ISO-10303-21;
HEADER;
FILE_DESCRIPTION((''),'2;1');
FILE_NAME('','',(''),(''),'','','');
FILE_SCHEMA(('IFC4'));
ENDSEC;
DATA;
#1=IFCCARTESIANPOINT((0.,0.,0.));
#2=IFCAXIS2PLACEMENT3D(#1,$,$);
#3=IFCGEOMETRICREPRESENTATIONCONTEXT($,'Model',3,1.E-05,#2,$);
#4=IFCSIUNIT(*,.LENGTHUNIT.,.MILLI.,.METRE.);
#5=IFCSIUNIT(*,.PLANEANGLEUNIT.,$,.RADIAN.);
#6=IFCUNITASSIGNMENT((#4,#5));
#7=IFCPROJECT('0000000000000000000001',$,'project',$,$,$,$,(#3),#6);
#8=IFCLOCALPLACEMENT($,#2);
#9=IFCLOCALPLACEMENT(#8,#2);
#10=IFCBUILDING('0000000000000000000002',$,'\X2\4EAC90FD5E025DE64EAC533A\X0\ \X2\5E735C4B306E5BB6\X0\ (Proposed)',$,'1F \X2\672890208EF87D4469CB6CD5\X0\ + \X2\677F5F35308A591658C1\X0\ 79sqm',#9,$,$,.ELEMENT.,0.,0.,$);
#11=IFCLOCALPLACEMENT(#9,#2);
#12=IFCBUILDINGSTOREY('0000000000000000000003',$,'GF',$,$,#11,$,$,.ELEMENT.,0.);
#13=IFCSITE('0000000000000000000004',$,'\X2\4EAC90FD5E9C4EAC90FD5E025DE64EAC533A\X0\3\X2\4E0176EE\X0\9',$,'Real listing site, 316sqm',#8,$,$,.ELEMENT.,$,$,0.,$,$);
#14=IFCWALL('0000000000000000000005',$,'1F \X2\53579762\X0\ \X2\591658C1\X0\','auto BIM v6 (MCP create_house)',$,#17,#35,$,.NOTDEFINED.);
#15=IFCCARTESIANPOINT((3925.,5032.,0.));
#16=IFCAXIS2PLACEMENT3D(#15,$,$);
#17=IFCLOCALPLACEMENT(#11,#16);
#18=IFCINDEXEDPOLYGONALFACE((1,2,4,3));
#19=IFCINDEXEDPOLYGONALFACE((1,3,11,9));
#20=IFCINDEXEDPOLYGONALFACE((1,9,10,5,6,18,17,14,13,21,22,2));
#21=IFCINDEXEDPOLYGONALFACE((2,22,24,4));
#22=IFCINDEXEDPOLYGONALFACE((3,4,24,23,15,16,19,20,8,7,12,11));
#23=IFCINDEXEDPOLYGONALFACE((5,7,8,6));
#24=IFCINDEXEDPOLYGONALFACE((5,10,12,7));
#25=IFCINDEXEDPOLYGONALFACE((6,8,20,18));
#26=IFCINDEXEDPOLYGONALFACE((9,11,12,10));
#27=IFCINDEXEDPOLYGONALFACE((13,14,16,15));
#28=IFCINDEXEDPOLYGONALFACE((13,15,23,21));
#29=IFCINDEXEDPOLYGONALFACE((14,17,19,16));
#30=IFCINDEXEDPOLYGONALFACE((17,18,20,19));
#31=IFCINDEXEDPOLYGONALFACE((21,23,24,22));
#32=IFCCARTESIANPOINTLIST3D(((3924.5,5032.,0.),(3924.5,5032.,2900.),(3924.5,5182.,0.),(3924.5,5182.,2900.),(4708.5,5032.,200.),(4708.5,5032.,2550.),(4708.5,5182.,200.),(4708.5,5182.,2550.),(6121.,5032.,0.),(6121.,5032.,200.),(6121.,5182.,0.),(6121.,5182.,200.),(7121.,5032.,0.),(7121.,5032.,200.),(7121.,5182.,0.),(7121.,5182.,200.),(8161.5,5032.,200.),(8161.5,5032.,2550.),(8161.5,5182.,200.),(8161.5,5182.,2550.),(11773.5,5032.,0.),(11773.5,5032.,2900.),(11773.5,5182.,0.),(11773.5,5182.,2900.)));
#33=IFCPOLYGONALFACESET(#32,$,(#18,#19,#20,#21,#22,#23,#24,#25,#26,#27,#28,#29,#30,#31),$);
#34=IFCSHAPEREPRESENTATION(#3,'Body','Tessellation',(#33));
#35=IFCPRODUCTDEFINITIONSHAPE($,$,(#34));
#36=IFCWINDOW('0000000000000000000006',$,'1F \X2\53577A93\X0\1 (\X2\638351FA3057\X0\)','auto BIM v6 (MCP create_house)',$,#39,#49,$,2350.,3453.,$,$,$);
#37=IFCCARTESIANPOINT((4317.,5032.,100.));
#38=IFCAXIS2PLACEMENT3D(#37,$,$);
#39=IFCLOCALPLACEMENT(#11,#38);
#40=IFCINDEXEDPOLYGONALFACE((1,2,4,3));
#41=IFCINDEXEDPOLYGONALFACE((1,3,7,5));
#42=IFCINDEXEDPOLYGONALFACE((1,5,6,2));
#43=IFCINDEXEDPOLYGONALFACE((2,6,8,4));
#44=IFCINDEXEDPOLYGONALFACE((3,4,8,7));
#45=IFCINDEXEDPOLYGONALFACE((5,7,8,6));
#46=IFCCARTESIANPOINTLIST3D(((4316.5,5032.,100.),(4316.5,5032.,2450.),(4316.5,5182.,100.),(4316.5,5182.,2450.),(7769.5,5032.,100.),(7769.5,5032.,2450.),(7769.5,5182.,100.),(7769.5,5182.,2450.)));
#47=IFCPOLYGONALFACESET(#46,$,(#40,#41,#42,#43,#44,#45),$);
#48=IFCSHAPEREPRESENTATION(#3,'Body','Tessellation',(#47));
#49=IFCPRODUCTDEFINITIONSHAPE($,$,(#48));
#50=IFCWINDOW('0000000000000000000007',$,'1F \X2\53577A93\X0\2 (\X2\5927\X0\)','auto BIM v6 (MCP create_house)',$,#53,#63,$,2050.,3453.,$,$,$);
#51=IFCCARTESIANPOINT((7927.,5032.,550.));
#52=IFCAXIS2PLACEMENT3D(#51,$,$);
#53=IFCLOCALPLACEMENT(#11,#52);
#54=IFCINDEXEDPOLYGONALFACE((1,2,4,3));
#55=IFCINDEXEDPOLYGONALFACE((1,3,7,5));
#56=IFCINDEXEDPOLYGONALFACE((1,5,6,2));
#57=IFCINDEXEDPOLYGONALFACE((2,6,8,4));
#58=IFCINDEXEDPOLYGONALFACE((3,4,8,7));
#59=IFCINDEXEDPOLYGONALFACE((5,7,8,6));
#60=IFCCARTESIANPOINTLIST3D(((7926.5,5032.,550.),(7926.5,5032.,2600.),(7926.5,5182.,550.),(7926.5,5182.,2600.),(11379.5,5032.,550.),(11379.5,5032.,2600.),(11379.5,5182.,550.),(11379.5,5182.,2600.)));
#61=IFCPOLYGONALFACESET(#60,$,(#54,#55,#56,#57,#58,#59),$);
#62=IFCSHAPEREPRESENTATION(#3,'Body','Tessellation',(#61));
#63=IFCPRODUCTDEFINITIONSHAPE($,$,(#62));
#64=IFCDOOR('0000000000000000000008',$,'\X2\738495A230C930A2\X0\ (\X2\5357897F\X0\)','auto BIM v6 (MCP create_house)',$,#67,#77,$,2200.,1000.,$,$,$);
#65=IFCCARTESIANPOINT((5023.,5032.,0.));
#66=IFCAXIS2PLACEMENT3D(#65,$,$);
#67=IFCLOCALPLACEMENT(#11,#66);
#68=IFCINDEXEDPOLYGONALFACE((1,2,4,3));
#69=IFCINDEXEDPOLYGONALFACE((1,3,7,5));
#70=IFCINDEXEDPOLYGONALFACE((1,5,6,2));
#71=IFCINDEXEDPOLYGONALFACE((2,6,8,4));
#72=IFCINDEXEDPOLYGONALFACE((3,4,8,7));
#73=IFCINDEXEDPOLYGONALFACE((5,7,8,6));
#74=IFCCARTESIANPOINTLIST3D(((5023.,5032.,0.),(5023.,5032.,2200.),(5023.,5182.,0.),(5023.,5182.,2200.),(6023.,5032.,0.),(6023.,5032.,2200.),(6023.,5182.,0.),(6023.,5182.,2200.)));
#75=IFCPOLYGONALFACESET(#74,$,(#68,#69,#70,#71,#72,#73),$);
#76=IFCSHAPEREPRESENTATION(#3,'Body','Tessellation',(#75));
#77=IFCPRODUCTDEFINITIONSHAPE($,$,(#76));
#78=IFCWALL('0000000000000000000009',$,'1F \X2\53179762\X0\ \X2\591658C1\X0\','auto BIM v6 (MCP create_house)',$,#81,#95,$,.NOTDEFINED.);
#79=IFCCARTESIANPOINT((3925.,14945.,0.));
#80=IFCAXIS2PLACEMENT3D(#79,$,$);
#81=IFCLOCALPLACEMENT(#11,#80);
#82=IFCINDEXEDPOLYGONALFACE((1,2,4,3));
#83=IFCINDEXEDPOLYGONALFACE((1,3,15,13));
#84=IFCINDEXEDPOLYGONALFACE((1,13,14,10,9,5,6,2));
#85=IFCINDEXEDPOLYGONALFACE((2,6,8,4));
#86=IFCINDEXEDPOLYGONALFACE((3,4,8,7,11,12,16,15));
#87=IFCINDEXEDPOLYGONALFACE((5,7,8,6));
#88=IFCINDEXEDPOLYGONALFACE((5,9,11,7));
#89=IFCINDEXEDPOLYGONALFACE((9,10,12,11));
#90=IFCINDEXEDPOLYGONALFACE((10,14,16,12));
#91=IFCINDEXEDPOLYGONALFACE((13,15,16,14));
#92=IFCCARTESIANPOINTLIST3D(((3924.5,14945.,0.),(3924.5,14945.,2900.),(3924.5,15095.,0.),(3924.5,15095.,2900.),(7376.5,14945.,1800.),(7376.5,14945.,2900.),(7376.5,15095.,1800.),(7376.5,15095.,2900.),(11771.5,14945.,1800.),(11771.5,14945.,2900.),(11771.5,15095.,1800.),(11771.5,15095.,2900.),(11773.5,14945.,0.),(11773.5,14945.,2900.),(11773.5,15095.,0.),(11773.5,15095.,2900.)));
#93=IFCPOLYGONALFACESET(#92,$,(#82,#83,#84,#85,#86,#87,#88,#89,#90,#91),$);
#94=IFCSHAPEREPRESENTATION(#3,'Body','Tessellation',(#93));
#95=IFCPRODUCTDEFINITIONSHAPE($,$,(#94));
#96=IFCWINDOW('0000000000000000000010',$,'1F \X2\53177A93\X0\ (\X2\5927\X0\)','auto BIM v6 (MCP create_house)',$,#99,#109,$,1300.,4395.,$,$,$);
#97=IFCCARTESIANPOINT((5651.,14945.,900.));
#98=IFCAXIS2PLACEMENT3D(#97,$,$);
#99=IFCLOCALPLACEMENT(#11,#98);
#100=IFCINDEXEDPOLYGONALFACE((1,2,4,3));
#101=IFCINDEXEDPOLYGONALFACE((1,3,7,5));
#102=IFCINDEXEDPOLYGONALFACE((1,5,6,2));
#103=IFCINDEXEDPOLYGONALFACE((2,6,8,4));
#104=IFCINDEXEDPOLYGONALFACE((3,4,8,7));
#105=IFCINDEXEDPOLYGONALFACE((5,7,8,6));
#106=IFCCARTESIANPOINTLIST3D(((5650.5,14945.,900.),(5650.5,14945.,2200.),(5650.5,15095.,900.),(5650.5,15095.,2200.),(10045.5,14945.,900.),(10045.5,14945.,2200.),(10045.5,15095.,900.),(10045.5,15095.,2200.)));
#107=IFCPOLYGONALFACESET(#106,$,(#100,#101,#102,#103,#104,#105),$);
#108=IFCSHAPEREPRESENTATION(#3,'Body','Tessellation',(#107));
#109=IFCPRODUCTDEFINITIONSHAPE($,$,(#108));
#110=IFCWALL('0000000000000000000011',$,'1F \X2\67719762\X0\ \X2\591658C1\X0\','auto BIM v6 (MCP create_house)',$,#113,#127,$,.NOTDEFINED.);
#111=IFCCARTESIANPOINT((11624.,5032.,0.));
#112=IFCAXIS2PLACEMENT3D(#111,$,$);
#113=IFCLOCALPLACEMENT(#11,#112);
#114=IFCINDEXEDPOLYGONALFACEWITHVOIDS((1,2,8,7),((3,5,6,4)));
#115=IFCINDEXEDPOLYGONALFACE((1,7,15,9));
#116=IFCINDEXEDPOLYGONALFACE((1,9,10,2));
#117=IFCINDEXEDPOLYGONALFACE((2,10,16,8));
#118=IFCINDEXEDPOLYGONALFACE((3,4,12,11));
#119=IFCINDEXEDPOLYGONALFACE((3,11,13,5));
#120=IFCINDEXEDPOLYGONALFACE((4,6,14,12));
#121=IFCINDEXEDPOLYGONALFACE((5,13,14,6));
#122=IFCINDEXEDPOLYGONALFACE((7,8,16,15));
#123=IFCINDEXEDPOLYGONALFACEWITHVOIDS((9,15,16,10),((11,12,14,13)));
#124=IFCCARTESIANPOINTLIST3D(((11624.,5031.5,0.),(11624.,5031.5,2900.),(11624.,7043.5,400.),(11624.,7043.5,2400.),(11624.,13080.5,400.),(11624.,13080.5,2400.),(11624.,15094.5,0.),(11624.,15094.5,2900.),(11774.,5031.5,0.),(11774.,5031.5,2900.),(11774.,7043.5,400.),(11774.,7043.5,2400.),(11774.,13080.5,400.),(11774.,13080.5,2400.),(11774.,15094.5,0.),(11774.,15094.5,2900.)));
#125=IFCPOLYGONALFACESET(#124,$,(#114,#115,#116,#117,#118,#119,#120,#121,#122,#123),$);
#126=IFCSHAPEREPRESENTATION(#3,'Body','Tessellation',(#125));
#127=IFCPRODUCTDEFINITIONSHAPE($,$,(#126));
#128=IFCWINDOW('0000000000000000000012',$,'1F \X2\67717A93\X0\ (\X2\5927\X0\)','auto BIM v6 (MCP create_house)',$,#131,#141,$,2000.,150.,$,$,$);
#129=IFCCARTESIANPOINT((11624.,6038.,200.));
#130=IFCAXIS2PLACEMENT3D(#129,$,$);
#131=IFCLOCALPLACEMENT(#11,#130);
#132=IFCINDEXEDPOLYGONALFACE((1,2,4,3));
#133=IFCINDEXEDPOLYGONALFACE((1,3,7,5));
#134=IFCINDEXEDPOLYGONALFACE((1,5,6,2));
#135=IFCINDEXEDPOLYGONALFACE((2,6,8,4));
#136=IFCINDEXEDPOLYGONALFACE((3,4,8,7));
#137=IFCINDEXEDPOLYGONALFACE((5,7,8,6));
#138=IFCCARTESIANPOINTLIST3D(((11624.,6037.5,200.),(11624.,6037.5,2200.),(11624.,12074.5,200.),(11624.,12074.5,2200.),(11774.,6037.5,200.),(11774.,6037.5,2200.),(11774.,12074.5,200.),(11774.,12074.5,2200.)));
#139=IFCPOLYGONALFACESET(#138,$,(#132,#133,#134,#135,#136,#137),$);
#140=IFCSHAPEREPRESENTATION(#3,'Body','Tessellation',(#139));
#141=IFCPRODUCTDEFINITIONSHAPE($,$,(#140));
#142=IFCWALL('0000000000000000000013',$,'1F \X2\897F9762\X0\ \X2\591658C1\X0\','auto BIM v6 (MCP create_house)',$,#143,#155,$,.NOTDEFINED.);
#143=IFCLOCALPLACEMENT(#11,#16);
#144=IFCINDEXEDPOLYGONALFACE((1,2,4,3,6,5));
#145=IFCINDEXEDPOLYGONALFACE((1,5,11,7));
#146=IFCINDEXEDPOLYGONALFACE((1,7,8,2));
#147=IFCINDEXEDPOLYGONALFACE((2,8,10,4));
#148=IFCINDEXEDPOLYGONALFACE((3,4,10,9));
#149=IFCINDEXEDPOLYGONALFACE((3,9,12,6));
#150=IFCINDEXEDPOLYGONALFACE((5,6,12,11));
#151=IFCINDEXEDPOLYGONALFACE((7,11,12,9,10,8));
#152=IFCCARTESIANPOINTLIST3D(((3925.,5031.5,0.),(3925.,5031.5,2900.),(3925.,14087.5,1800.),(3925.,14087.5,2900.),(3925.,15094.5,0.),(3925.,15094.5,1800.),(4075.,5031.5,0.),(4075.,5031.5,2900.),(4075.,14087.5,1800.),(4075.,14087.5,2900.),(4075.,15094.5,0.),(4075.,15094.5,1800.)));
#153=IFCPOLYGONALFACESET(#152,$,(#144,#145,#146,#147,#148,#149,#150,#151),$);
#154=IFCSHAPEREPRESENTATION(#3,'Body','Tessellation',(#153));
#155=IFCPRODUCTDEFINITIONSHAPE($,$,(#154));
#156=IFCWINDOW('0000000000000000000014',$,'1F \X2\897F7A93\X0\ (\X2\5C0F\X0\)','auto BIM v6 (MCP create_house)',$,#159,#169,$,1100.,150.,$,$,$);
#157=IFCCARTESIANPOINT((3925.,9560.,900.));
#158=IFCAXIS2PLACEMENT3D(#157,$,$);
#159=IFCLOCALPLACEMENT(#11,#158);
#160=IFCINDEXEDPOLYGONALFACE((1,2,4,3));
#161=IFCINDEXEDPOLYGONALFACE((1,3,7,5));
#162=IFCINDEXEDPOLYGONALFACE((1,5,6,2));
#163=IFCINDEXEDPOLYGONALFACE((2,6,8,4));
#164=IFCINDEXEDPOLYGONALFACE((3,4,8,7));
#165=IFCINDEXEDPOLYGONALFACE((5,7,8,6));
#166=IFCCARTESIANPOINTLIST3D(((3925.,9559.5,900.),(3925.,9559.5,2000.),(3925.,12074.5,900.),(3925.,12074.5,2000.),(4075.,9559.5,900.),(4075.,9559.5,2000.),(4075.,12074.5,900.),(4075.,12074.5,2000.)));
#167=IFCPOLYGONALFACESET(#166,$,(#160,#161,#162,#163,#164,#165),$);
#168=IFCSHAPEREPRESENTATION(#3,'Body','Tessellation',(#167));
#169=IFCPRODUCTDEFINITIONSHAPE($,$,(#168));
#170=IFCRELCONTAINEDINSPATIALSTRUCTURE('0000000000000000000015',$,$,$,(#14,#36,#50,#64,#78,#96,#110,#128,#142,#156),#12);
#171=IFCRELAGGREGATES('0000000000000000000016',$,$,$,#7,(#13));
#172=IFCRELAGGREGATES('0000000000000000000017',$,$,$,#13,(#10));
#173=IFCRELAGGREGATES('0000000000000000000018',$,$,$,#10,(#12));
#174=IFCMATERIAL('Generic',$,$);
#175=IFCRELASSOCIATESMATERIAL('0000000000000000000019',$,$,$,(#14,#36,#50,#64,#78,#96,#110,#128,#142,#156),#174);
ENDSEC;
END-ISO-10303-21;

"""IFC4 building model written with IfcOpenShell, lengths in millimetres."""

from ifc_helpers import new_model, si_unit, frame, frame_2d, origin, place, context, project, spatial, rectangle, extrude, material, element, fill, save


model = new_model("IFC4")

# Units and contexts
model_context = context("Model", 3, precision=1e-05, world=origin())
ifc_project = project(units=[si_unit("LENGTHUNIT", "METRE", prefix="MILLI"), si_unit("PLANEANGLEUNIT", "RADIAN")], contexts=[model_context])

# Site, building, storey
site_placement = place(None, origin())
site = spatial("IfcSite", under=ifc_project, at=site_placement, Name="京都府京都市左京区3丁目9", ObjectType="Real listing site, 316sqm", CompositionType="ELEMENT", RefElevation=0.0)
building_placement = place(site_placement, origin())
building = spatial("IfcBuilding", under=site, at=building_placement, Name="京都市左京区 平屋の家 (Proposed)", ObjectType="1F 木造軸組構法 + 板張り外壁 79sqm", CompositionType="ELEMENT", ElevationOfRefHeight=0.0, ElevationOfTerrain=0.0)
storey_placement = place(building_placement, origin())
storey = spatial("IfcBuildingStorey", under=building, at=storey_placement, Name="GF", CompositionType="ELEMENT", Elevation=0.0)

# Shared definitions
ifc_material = material(Name="Generic")

# Wall, openings, windows, door
wall_1_placement = place(storey_placement, frame((3925.0, 5032.0, 0.0)))
wall_1 = element("IfcWall", 1, at=wall_1_placement, inside=storey, material=ifc_material, Name="1F 南面 外壁", Description="auto BIM v6 (MCP create_house)", PredefinedType="NOTDEFINED", context=model_context, shape_type="SweptSolid", body=[
    extrude(rectangle(XDim=7849.0, YDim=150.0, at=frame_2d((3924.0, 75.0))), frame((3925.0, 5032.0, 0.0)), (0.0, 0.0, 1.0), 2900.0),
])
opening_1_placement = place(storey_placement, frame((4317.0, 5032.0, 100.0)))
opening_1 = element("IfcOpeningElement", 2, at=opening_1_placement, cuts=wall_1, PredefinedType="NOTDEFINED", context=model_context, shape_type="SweptSolid", body=[
    extrude(rectangle(XDim=3453.0, YDim=150.0, at=frame_2d((1726.0, 75.0))), frame((4317.0, 5032.0, 100.0)), (0.0, 0.0, 1.0), 2350.0),
])
opening_2_placement = place(storey_placement, frame((7927.0, 5032.0, 550.0)))
opening_2 = element("IfcOpeningElement", 3, at=opening_2_placement, cuts=wall_1, PredefinedType="NOTDEFINED", context=model_context, shape_type="SweptSolid", body=[
    extrude(rectangle(XDim=3453.0, YDim=150.0, at=frame_2d((1726.0, 75.0))), frame((7927.0, 5032.0, 550.0)), (0.0, 0.0, 1.0), 2050.0),
])
opening_3_placement = place(storey_placement, frame((5023.0, 5032.0, 0.0)))
opening_3 = element("IfcOpeningElement", 4, at=opening_3_placement, cuts=wall_1, PredefinedType="NOTDEFINED", context=model_context, shape_type="SweptSolid", body=[
    extrude(rectangle(XDim=1000.0, YDim=150.0, at=frame_2d((500.0, 75.0))), frame((5023.0, 5032.0, 0.0)), (0.0, 0.0, 1.0), 2200.0),
])
window_1_placement = place(storey_placement, frame((4317.0, 5032.0, 100.0)))
window_1 = element("IfcWindow", 5, at=window_1_placement, inside=storey, material=ifc_material, Name="1F 南窓1 (掃出し)", Description="auto BIM v6 (MCP create_house)", OverallHeight=2350.0, OverallWidth=3453.0, context=model_context, shape_type="SweptSolid", body=[
    extrude(rectangle(XDim=3453.0, YDim=150.0, at=frame_2d((1726.0, 75.0))), frame((4317.0, 5032.0, 100.0)), (0.0, 0.0, 1.0), 2350.0),
])
fill(opening_1, window_1)
window_2_placement = place(storey_placement, frame((7927.0, 5032.0, 550.0)))
window_2 = element("IfcWindow", 6, at=window_2_placement, inside=storey, material=ifc_material, Name="1F 南窓2 (大)", Description="auto BIM v6 (MCP create_house)", OverallHeight=2050.0, OverallWidth=3453.0, context=model_context, shape_type="SweptSolid", body=[
    extrude(rectangle(XDim=3453.0, YDim=150.0, at=frame_2d((1726.0, 75.0))), frame((7927.0, 5032.0, 550.0)), (0.0, 0.0, 1.0), 2050.0),
])
fill(opening_2, window_2)
door_placement = place(storey_placement, frame((5023.0, 5032.0, 0.0)))
door = element("IfcDoor", 7, at=door_placement, inside=storey, material=ifc_material, Name="玄関ドア (南西)", Description="auto BIM v6 (MCP create_house)", OverallHeight=2200.0, OverallWidth=1000.0, context=model_context, shape_type="SweptSolid", body=[
    extrude(rectangle(XDim=1000.0, YDim=150.0, at=frame_2d((500.0, 75.0))), frame((5023.0, 5032.0, 0.0)), (0.0, 0.0, 1.0), 2200.0),
])
fill(opening_3, door)

# Walls, openings, windows
wall_2_placement = place(storey_placement, frame((3925.0, 14945.0, 0.0)))
wall_2 = element("IfcWall", 8, at=wall_2_placement, inside=storey, material=ifc_material, Name="1F 北面 外壁", Description="auto BIM v6 (MCP create_house)", PredefinedType="NOTDEFINED", context=model_context, shape_type="SweptSolid", body=[
    extrude(rectangle(XDim=7849.0, YDim=150.0, at=frame_2d((3924.0, 75.0))), frame((3925.0, 14945.0, 0.0)), (0.0, 0.0, 1.0), 2900.0),
])
opening_4_placement = place(storey_placement, frame((5651.0, 14945.0, 900.0)))
opening_4 = element("IfcOpeningElement", 9, at=opening_4_placement, cuts=wall_2, PredefinedType="NOTDEFINED", context=model_context, shape_type="SweptSolid", body=[
    extrude(rectangle(XDim=4395.0, YDim=150.0, at=frame_2d((2197.0, 75.0))), frame((5651.0, 14945.0, 900.0)), (0.0, 0.0, 1.0), 1300.0),
])
window_3_placement = place(storey_placement, frame((5651.0, 14945.0, 900.0)))
window_3 = element("IfcWindow", 10, at=window_3_placement, inside=storey, material=ifc_material, Name="1F 北窓 (大)", Description="auto BIM v6 (MCP create_house)", OverallHeight=1300.0, OverallWidth=4395.0, context=model_context, shape_type="SweptSolid", body=[
    extrude(rectangle(XDim=4395.0, YDim=150.0, at=frame_2d((2197.0, 75.0))), frame((5651.0, 14945.0, 900.0)), (0.0, 0.0, 1.0), 1300.0),
])
fill(opening_4, window_3)
wall_3_placement = place(storey_placement, frame((11624.0, 5032.0, 0.0)))
wall_3 = element("IfcWall", 11, at=wall_3_placement, inside=storey, material=ifc_material, Name="1F 東面 外壁", Description="auto BIM v6 (MCP create_house)", PredefinedType="NOTDEFINED", context=model_context, shape_type="SweptSolid", body=[
    extrude(rectangle(XDim=150.0, YDim=10063.0, at=frame_2d((75.0, 5031.0))), frame((11624.0, 5032.0, 0.0)), (0.0, 0.0, 1.0), 2900.0),
])
opening_5_placement = place(storey_placement, frame((11624.0, 6038.0, 200.0)))
opening_5 = element("IfcOpeningElement", 12, at=opening_5_placement, cuts=wall_3, PredefinedType="NOTDEFINED", context=model_context, shape_type="SweptSolid", body=[
    extrude(rectangle(XDim=150.0, YDim=6037.0, at=frame_2d((75.0, 3018.0))), frame((11624.0, 6038.0, 200.0)), (0.0, 0.0, 1.0), 2000.0),
])
window_4_placement = place(storey_placement, frame((11624.0, 6038.0, 200.0)))
window_4 = element("IfcWindow", 13, at=window_4_placement, inside=storey, material=ifc_material, Name="1F 東窓 (大)", Description="auto BIM v6 (MCP create_house)", OverallHeight=2000.0, OverallWidth=150.0, context=model_context, shape_type="SweptSolid", body=[
    extrude(rectangle(XDim=150.0, YDim=6037.0, at=frame_2d((75.0, 3018.0))), frame((11624.0, 6038.0, 200.0)), (0.0, 0.0, 1.0), 2000.0),
])
fill(opening_5, window_4)
wall_4_placement = place(storey_placement, frame((3925.0, 5032.0, 0.0)))
wall_4 = element("IfcWall", 14, at=wall_4_placement, inside=storey, material=ifc_material, Name="1F 西面 外壁", Description="auto BIM v6 (MCP create_house)", PredefinedType="NOTDEFINED", context=model_context, shape_type="SweptSolid", body=[
    extrude(rectangle(XDim=150.0, YDim=10063.0, at=frame_2d((75.0, 5031.0))), frame((3925.0, 5032.0, 0.0)), (0.0, 0.0, 1.0), 2900.0),
])
opening_6_placement = place(storey_placement, frame((3925.0, 9560.0, 900.0)))
opening_6 = element("IfcOpeningElement", 15, at=opening_6_placement, cuts=wall_4, PredefinedType="NOTDEFINED", context=model_context, shape_type="SweptSolid", body=[
    extrude(rectangle(XDim=150.0, YDim=2515.0, at=frame_2d((75.0, 1257.0))), frame((3925.0, 9560.0, 900.0)), (0.0, 0.0, 1.0), 1100.0),
])
window_5_placement = place(storey_placement, frame((3925.0, 9560.0, 900.0)))
window_5 = element("IfcWindow", 16, at=window_5_placement, inside=storey, material=ifc_material, Name="1F 西窓 (小)", Description="auto BIM v6 (MCP create_house)", OverallHeight=1100.0, OverallWidth=150.0, context=model_context, shape_type="SweptSolid", body=[
    extrude(rectangle(XDim=150.0, YDim=2515.0, at=frame_2d((75.0, 1257.0))), frame((3925.0, 9560.0, 900.0)), (0.0, 0.0, 1.0), 1100.0),
])
fill(opening_6, window_5)

save(model, "model.ifc")
